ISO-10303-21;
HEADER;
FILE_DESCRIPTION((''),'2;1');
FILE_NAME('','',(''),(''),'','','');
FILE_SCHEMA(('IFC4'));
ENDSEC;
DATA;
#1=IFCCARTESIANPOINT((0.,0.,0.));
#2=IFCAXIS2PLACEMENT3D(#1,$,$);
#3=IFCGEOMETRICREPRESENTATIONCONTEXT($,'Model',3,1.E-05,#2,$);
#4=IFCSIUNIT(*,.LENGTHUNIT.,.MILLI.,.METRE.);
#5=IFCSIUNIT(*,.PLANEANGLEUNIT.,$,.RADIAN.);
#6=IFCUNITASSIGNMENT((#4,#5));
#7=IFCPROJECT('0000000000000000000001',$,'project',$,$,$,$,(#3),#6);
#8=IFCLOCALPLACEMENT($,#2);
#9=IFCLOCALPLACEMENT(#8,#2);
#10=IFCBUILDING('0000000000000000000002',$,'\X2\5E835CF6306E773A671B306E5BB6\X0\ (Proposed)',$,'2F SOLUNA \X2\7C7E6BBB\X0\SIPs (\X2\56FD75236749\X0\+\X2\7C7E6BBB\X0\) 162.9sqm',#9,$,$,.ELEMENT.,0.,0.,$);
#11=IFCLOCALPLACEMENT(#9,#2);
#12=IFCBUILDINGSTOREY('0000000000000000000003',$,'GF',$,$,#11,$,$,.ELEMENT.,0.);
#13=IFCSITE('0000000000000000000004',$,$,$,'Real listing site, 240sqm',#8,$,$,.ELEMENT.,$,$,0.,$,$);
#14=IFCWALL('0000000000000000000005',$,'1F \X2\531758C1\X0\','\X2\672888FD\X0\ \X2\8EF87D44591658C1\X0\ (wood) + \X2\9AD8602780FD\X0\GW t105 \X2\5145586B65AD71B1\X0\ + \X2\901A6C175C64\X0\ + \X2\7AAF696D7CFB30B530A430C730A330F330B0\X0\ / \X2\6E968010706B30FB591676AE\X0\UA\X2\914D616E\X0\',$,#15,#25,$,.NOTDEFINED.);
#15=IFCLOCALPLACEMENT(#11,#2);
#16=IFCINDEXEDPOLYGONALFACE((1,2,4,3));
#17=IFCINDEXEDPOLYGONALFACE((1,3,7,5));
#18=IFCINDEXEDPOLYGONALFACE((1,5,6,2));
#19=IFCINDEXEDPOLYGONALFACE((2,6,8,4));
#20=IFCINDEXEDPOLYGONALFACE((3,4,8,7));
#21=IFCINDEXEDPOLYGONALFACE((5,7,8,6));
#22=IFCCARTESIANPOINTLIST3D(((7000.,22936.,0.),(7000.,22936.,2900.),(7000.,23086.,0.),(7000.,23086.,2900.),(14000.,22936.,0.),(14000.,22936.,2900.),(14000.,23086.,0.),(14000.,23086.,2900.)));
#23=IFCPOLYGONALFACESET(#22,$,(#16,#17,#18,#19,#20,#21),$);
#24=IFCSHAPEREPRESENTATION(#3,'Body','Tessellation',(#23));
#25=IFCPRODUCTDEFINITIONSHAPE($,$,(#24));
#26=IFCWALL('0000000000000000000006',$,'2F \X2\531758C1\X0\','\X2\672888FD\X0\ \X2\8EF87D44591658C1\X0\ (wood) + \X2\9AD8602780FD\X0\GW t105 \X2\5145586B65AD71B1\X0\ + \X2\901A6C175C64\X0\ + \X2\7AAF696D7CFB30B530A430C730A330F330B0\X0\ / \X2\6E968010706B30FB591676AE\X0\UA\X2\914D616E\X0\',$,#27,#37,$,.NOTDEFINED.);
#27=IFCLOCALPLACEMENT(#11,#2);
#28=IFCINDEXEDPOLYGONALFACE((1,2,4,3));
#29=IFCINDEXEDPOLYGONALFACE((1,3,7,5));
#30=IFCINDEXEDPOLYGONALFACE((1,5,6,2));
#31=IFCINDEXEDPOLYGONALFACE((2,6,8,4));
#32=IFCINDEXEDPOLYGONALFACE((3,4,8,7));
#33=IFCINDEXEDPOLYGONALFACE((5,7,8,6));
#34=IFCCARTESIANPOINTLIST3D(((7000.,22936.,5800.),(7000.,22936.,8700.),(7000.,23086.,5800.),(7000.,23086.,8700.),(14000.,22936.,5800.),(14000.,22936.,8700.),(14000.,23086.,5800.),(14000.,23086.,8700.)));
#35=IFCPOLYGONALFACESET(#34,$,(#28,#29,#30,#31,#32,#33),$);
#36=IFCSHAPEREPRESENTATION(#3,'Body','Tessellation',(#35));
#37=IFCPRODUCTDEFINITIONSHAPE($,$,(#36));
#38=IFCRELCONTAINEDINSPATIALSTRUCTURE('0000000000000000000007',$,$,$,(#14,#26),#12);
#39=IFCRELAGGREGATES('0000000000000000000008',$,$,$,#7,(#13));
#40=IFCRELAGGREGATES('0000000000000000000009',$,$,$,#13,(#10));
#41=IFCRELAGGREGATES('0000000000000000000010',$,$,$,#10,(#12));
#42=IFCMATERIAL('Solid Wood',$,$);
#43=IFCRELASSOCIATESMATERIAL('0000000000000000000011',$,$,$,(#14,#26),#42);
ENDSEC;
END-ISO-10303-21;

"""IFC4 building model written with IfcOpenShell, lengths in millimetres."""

from ifc_helpers import new_model, si_unit, frame, frame_2d, origin, place, context, project, spatial, rectangle, extrude, material, element, save


model = new_model("IFC4")

# Units and contexts
model_context = context("Model", 3, precision=1e-05, world=origin())
ifc_project = project(units=[si_unit("LENGTHUNIT", "METRE", prefix="MILLI"), si_unit("PLANEANGLEUNIT", "RADIAN")], contexts=[model_context])

# Site, building, storey
site_placement = place(None, origin())
site = spatial("IfcSite", under=ifc_project, at=site_placement, ObjectType="Real listing site, 240sqm", CompositionType="ELEMENT", RefElevation=0.0)
building_placement = place(site_placement, origin())
building = spatial("IfcBuilding", under=site, at=building_placement, Name="広島の眺望の家 (Proposed)", ObjectType="2F SOLUNA 籾殻SIPs (国産杉+籾殻) 162.9sqm", CompositionType="ELEMENT", ElevationOfRefHeight=0.0, ElevationOfTerrain=0.0)
storey_placement = place(building_placement, origin())
storey = spatial("IfcBuildingStorey", under=building, at=storey_placement, Name="GF", CompositionType="ELEMENT", Elevation=0.0)

# Shared definitions
ifc_material_1 = material(Name="Solid Wood")

# Wall
wall_1_placement = place(storey_placement, frame((3500.0, 11468.0, 0.0)))
element("IfcWall", 1, at=wall_1_placement, inside=storey, material=ifc_material_1, Name="1F 北壁", Description="木製 軸組外壁 (wood) + 高性能GW t105 充填断熱 + 通気層 + 窯業系サイディング / 準耐火・外皮UA配慮", PredefinedType="NOTDEFINED", context=model_context, shape_type="SweptSolid", body=[
    extrude(rectangle(XDim=7000.0, YDim=150.0, at=frame_2d((3500.0, 75.0))), frame((3500.0, 11468.0, 0.0)), (0.0, 0.0, 1.0), 2900.0),
])

# Wall
wall_2_placement = place(storey_placement, frame((3500.0, 11468.0, 2900.0)))
element("IfcWall", 2, at=wall_2_placement, inside=storey, material=ifc_material_1, Name="2F 北壁", Description="木製 軸組外壁 (wood) + 高性能GW t105 充填断熱 + 通気層 + 窯業系サイディング / 準耐火・外皮UA配慮", PredefinedType="NOTDEFINED", context=model_context, shape_type="SweptSolid", body=[
    extrude(rectangle(XDim=7000.0, YDim=150.0, at=frame_2d((3500.0, 75.0))), frame((3500.0, 11468.0, 2900.0)), (0.0, 0.0, 1.0), 2900.0),
])

save(model, "model.ifc")
